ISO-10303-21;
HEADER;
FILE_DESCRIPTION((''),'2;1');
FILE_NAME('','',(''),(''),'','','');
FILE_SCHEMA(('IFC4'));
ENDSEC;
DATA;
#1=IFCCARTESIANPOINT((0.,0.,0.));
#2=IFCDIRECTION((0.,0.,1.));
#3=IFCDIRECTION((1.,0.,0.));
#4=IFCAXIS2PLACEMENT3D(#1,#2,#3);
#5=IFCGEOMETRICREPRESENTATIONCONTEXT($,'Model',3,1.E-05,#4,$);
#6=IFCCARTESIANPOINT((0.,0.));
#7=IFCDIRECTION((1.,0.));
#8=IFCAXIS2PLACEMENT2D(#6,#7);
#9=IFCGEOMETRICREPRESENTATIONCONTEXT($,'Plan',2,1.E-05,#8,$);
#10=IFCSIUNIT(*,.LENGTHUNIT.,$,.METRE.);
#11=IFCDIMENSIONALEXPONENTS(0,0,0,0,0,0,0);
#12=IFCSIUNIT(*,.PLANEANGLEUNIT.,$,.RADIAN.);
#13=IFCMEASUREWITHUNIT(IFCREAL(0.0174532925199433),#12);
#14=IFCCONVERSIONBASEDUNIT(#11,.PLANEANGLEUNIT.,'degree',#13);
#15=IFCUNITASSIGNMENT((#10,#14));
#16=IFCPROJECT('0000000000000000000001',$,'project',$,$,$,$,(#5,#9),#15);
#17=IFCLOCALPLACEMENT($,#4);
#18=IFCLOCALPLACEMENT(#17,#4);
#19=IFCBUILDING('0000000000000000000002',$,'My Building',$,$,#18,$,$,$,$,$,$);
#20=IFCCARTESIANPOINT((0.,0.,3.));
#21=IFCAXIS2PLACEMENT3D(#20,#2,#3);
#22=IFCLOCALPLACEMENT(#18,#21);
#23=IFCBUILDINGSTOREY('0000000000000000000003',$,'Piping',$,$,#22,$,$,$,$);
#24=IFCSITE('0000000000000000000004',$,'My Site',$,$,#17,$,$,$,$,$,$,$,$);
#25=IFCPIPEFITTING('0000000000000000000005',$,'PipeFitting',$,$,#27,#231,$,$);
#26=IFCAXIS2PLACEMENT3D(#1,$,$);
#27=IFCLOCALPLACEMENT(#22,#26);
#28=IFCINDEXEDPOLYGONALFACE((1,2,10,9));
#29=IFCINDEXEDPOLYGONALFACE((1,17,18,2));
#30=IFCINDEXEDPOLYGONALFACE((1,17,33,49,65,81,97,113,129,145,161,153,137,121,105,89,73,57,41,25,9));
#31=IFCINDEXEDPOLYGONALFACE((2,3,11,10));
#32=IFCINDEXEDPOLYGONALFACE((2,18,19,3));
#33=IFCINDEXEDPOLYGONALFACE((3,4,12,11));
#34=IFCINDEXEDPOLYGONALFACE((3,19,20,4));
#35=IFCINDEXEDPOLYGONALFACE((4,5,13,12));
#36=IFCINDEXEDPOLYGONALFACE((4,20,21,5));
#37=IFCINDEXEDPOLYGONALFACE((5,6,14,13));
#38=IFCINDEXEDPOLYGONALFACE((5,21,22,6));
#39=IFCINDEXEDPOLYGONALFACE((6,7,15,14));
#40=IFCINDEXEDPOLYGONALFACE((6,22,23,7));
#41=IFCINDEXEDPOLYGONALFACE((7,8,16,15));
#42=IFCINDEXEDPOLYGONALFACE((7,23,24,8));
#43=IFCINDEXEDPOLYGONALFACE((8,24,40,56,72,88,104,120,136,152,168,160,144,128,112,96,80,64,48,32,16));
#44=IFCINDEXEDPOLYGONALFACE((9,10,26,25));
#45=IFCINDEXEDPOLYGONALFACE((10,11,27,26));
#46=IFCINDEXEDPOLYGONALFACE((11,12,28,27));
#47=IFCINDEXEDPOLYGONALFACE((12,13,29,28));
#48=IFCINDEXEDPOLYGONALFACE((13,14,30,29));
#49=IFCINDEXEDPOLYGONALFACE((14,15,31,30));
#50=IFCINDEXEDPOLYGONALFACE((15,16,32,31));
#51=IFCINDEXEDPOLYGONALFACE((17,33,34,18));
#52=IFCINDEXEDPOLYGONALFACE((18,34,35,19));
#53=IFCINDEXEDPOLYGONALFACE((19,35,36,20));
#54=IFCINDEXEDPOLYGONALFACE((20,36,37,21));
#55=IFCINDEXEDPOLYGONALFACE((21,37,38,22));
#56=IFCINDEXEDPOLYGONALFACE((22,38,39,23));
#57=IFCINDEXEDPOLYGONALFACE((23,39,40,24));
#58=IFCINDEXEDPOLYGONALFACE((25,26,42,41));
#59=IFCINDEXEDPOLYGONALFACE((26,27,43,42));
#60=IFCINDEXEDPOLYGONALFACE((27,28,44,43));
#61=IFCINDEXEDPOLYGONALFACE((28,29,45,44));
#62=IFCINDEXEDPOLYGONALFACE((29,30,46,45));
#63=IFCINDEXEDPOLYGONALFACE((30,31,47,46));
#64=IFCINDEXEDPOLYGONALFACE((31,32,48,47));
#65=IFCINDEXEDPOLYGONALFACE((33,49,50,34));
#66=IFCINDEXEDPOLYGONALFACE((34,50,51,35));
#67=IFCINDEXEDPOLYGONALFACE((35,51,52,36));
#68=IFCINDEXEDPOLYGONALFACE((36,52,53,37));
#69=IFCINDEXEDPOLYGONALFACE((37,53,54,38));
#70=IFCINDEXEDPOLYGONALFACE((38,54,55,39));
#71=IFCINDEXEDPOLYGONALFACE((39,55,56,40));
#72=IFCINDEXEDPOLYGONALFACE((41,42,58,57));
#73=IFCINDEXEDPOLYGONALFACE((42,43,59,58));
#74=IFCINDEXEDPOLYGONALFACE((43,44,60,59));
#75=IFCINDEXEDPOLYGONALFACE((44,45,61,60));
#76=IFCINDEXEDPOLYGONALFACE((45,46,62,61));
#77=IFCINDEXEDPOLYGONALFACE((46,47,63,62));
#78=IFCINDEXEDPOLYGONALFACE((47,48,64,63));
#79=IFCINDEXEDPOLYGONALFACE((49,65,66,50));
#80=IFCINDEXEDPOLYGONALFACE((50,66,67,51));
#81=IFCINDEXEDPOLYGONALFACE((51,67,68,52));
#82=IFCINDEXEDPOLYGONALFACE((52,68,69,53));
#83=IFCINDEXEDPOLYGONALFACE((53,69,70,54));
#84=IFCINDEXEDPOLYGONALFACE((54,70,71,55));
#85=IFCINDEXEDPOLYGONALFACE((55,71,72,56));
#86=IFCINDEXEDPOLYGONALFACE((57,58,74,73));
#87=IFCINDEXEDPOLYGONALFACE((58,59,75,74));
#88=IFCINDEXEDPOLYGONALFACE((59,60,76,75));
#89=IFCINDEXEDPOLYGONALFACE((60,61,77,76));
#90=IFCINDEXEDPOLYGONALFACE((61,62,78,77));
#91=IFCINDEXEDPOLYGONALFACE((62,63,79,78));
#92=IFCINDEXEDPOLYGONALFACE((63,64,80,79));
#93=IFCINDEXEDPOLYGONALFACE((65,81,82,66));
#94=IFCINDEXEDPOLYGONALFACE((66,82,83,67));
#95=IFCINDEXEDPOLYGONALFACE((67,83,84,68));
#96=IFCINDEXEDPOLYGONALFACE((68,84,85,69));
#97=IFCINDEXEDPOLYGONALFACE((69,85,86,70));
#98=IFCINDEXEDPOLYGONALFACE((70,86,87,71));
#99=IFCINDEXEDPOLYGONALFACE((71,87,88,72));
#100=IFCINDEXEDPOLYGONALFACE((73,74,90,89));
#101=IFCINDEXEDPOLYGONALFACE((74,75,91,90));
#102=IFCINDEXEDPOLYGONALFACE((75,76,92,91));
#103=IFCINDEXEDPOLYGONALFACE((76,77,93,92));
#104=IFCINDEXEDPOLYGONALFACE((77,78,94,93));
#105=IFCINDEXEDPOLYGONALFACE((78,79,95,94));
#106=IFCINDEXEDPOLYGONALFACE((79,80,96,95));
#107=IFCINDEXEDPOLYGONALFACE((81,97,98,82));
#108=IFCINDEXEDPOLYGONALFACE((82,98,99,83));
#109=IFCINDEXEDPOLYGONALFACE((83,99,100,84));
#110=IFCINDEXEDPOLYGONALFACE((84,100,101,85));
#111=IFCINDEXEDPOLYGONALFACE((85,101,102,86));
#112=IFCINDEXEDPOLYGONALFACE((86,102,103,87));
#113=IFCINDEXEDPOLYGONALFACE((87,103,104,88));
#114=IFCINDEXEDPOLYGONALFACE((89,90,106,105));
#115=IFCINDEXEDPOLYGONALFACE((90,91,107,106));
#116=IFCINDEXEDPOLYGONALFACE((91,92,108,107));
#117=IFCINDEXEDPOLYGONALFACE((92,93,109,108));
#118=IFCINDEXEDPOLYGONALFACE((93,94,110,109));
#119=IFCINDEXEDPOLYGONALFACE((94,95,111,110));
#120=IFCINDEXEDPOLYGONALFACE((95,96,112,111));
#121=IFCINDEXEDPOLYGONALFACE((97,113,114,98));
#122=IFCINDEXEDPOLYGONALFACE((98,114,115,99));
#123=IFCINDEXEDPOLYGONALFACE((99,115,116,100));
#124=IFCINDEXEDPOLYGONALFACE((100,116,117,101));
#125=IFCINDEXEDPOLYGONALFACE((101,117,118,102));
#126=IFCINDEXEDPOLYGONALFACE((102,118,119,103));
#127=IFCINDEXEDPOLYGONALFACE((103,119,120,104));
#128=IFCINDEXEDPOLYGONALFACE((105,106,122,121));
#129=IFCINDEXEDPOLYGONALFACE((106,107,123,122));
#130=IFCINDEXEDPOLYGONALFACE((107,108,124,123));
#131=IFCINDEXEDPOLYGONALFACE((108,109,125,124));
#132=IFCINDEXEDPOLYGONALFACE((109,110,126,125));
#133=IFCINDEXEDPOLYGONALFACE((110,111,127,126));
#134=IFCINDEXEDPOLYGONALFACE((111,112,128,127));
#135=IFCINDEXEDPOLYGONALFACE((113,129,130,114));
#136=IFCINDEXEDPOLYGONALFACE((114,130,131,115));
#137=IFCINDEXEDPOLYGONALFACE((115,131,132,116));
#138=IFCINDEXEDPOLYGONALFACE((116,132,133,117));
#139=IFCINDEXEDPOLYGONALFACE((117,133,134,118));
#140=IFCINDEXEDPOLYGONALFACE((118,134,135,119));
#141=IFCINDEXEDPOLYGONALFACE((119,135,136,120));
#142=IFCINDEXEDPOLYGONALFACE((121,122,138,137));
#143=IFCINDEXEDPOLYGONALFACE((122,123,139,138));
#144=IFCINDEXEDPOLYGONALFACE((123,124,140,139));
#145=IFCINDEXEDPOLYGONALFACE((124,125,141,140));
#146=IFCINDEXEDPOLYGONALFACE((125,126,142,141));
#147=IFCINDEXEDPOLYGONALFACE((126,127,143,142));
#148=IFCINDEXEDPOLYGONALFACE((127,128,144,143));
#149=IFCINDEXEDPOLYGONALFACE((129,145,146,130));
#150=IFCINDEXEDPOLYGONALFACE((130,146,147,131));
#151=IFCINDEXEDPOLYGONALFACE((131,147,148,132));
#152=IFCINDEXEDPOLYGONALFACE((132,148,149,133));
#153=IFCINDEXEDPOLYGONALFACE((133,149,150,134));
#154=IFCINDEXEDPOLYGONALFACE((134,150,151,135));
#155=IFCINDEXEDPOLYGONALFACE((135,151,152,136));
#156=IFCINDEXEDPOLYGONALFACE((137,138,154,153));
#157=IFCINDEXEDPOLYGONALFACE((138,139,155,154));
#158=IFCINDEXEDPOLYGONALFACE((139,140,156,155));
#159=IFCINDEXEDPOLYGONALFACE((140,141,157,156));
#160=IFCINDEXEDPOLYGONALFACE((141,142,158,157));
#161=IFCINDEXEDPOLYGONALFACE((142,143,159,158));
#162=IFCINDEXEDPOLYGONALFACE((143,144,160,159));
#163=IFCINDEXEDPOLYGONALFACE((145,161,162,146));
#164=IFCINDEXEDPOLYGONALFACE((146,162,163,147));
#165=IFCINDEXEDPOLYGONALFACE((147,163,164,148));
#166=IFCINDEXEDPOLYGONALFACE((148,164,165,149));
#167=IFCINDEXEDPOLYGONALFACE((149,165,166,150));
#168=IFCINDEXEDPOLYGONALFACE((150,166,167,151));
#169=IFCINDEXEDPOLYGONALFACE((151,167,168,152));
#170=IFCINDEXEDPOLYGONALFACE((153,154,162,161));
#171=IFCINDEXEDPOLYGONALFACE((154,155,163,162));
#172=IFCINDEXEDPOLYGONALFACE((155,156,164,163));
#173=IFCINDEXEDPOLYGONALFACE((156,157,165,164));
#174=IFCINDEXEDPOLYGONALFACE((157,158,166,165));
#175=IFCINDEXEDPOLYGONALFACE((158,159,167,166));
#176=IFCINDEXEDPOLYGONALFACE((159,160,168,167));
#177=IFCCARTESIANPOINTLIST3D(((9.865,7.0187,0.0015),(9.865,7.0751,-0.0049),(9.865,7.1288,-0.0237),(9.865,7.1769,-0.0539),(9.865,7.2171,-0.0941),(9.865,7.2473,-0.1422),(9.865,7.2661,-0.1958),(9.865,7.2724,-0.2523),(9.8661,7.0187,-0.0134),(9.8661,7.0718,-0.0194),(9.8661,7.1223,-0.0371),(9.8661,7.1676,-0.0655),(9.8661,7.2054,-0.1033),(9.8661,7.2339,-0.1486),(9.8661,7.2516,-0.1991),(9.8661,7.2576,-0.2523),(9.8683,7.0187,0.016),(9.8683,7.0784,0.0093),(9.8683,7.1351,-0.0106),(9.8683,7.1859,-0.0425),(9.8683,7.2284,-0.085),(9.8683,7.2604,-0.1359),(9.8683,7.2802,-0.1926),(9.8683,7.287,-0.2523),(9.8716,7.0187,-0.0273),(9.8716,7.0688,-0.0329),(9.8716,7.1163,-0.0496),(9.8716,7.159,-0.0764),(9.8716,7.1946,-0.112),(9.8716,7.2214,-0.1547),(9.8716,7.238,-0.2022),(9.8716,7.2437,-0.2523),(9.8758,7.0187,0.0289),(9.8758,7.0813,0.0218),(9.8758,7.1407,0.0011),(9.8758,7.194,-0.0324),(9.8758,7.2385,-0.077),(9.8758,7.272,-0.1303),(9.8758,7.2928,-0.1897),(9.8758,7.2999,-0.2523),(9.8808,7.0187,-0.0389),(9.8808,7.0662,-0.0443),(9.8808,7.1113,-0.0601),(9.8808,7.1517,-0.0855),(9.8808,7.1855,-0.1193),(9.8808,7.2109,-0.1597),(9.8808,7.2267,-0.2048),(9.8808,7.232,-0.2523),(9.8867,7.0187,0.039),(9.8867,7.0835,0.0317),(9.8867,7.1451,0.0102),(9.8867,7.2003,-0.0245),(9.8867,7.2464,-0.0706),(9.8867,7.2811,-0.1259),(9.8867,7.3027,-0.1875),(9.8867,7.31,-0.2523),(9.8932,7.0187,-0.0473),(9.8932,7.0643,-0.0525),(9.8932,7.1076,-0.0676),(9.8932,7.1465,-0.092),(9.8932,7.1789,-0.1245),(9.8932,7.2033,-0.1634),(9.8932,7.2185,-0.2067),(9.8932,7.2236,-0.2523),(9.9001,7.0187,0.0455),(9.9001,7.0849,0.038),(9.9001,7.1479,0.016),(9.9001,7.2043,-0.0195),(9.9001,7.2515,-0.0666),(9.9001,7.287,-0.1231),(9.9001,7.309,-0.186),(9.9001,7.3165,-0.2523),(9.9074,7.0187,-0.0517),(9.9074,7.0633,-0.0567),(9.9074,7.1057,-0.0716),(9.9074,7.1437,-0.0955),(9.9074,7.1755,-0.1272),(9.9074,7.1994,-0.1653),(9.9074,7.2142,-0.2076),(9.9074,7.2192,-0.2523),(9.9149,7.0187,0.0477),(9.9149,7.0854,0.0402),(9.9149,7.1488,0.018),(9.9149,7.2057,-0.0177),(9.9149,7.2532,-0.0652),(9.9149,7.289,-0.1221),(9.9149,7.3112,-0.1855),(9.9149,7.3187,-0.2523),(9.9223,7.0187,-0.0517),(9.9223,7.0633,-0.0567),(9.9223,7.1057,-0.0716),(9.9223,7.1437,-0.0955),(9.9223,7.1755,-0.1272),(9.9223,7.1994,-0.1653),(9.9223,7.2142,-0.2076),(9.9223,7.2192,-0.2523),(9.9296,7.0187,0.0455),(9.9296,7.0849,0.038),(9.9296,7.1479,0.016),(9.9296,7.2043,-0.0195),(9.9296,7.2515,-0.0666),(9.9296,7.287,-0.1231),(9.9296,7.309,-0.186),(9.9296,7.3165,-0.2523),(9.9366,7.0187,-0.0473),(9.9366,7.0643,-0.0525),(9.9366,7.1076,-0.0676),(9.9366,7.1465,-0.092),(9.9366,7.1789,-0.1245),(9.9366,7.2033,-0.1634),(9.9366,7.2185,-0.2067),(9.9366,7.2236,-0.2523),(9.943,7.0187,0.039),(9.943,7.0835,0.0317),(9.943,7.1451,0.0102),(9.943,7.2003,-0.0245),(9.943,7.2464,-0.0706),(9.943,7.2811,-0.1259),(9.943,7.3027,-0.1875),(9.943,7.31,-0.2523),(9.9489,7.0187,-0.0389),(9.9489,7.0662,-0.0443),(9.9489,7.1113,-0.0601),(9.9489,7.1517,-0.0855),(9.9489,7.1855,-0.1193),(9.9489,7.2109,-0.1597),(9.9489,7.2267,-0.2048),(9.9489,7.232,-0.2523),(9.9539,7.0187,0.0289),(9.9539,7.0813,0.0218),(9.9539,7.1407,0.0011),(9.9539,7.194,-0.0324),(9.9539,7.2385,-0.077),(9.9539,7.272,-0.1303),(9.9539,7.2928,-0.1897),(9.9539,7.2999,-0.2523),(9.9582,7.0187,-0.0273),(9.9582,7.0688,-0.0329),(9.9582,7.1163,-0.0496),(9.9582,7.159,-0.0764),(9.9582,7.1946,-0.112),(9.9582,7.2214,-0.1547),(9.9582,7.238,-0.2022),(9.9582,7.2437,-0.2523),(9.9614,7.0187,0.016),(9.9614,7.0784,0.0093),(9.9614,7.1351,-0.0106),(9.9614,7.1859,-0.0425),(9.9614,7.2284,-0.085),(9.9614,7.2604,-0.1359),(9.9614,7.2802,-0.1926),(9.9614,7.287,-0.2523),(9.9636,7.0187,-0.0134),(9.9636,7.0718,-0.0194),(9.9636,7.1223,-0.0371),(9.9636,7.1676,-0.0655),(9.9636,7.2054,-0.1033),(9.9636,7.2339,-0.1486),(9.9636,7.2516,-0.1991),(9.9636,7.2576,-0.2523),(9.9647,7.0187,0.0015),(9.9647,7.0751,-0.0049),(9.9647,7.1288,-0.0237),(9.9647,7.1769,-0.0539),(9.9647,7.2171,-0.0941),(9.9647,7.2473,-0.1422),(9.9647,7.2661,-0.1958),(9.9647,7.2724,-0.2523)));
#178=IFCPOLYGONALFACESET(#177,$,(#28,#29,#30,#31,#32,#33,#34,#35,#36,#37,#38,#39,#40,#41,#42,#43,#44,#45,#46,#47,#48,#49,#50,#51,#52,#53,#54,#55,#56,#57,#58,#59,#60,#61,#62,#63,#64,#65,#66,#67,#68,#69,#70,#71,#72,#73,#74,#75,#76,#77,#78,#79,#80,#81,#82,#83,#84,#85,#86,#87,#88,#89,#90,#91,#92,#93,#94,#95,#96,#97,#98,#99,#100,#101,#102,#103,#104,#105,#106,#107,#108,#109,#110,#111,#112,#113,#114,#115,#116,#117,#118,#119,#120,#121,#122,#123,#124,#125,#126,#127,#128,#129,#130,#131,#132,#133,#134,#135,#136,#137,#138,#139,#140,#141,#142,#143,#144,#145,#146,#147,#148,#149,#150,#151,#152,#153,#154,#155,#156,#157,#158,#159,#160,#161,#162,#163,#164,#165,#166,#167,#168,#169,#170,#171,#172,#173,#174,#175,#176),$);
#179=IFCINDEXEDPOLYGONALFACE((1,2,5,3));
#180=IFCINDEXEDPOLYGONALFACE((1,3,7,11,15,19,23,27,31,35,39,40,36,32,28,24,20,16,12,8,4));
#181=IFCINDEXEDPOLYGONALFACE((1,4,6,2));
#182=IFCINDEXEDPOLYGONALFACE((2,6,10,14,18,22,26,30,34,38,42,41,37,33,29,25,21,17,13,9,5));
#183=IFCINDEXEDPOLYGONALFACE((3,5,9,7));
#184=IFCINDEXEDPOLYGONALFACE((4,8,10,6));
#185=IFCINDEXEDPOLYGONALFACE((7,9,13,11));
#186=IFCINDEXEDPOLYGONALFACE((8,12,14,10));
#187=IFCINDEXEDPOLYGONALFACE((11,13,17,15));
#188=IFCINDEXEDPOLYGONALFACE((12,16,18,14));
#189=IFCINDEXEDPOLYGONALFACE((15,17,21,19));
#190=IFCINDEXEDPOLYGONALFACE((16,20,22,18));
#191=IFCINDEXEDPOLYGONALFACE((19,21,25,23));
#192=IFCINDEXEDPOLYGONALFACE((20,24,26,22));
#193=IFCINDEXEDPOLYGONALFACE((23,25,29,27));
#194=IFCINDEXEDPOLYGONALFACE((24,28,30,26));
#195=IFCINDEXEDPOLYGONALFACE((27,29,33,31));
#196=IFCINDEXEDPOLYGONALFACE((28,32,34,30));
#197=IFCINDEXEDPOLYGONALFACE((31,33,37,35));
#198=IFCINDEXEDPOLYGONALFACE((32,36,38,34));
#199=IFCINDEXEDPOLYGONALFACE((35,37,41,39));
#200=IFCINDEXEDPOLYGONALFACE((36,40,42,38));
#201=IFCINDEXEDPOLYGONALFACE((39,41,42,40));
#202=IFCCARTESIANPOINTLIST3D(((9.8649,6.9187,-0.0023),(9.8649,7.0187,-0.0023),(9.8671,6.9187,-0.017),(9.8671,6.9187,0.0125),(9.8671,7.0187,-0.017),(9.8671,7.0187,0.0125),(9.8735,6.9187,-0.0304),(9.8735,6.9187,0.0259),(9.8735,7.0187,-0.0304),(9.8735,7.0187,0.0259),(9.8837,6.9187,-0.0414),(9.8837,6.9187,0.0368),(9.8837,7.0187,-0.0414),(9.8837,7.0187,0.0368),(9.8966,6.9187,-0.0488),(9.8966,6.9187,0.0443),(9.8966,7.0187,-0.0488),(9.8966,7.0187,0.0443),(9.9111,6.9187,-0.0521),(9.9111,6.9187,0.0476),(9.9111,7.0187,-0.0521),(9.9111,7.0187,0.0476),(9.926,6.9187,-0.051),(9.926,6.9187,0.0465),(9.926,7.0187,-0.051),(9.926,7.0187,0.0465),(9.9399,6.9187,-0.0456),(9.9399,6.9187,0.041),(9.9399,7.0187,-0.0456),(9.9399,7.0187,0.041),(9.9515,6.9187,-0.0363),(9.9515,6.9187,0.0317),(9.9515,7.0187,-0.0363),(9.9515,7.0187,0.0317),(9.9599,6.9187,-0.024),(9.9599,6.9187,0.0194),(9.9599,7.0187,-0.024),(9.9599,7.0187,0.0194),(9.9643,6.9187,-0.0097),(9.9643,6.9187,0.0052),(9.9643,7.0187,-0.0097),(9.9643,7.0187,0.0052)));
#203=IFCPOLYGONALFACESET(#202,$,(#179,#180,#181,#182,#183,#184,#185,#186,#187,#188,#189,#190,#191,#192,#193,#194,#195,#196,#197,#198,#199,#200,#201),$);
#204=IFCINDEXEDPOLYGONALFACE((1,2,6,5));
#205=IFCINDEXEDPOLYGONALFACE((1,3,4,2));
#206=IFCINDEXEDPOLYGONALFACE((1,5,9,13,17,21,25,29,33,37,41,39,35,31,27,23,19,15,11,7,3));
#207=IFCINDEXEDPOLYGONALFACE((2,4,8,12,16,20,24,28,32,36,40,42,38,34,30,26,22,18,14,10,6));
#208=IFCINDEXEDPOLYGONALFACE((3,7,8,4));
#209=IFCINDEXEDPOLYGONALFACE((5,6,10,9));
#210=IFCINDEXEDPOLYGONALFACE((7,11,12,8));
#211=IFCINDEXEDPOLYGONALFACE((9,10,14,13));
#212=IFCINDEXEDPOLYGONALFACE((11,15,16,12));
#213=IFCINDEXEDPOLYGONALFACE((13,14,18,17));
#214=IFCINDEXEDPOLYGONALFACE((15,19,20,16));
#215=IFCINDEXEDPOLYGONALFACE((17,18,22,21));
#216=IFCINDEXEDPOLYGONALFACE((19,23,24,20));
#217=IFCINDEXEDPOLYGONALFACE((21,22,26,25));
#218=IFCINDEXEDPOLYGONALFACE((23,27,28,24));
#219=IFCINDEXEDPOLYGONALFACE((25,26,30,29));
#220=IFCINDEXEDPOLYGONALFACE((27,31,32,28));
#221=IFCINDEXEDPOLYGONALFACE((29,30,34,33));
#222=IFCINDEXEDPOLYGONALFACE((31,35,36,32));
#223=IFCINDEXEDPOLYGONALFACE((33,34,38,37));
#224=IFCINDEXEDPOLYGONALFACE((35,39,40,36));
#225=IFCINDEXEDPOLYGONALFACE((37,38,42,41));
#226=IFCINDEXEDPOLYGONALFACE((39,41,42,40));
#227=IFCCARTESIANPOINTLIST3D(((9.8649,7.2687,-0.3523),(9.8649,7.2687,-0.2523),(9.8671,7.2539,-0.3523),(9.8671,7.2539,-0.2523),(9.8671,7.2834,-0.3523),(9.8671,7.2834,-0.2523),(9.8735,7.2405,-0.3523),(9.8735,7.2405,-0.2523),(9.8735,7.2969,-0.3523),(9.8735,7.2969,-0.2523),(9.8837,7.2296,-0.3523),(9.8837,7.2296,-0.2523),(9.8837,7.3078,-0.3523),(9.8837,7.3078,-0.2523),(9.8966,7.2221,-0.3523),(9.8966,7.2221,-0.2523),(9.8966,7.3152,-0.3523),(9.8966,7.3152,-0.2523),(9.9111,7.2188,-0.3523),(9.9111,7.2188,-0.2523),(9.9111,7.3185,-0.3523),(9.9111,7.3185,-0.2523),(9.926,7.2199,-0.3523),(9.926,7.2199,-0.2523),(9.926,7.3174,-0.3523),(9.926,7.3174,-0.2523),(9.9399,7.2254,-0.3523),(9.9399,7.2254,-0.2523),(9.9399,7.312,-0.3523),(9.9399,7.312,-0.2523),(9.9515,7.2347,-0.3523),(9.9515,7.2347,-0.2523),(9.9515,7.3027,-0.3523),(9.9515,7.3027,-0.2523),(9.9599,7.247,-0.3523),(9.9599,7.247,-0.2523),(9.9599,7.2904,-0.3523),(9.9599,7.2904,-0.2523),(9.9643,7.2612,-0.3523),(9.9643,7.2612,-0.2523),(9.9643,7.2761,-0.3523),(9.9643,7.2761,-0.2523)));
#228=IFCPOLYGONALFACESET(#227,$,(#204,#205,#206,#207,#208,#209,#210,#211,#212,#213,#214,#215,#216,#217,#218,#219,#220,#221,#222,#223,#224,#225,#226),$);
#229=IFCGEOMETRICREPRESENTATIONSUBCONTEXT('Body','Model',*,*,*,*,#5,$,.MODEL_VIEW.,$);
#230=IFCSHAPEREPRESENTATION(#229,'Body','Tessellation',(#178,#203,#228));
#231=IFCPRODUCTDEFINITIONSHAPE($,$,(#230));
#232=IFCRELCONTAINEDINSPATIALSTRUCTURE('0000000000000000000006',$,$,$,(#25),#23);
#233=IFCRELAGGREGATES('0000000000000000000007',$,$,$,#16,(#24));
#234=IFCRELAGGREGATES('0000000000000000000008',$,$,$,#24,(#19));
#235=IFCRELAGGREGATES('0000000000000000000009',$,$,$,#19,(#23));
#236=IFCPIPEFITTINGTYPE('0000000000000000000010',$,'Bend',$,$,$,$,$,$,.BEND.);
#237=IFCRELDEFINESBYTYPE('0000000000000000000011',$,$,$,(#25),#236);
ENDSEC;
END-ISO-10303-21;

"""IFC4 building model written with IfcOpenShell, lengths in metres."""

from ifc_helpers import new_model, entity, si_unit, converted_unit, frame, origin_with_axes, origin_2d_with_axis, place, context, subcontext, project, spatial, circle, extrude, source, transform, mapped, type_object, type_shapes, element, save


model = new_model("IFC4")

# Units and contexts
model_context = context("Model", 3, precision=1e-05, world=origin_with_axes())
plan_context = context("Plan", 2, precision=1e-05, world=origin_2d_with_axis())
body_context = subcontext(model_context, "Body", "Model", "MODEL_VIEW")
ifc_project = project(units=[si_unit("LENGTHUNIT", "METRE"), converted_unit("PLANEANGLEUNIT", "degree", entity("IfcReal", 0.0174532925199433), si_unit("PLANEANGLEUNIT", "RADIAN"), dimensions=[0, 0, 0, 0, 0, 0, 0])], contexts=[model_context, plan_context])

# Site, building, storey
site_placement = place(None, origin_with_axes())
site = spatial("IfcSite", under=ifc_project, at=site_placement, Name="My Site")
building_placement = place(site_placement, origin_with_axes())
building = spatial("IfcBuilding", under=site, at=building_placement, Name="My Building")
storey_placement = place(building_placement, frame((0.0, 0.0, 3.0), z_axis=(0.0, 0.0, 1.0), x_axis=(1.0, 0.0, 0.0)))
storey = spatial("IfcBuildingStorey", under=building, at=storey_placement, Name="Piping")

# Pipe fitting
pipe_fitting_type_1 = type_object("IfcPipeFittingType", Name="Bend", PredefinedType="BEND")
shared_shape = source(origin_with_axes(), body_context, "Body", "SolidModel", [
    entity("IfcSweptDiskSolid", entity("IfcIndexedPolyCurve", entity("IfcCartesianPointList3D", [[0.0, 0.0, -0.1], [0.0, 0.0732, -0.2768], [0.0, 0.25, -0.35]]), [entity("IfcArcIndex", [1, 2, 3])]), 0.05),
    extrude(circle(Radius=0.05), origin_with_axes(), (0.0, 0.0, -1.0), 0.1),
    extrude(circle(Radius=0.05), frame((0.0, 0.25, -0.35), z_axis=(0.0, 1.0, 0.0), x_axis=(1.0, 0.0, 0.0)), (0.0, 0.0, 1.0), 0.1),
])
type_shapes(pipe_fitting_type_1, [shared_shape])
for number, where, z_axis, x_axis, name in (
    (1, (9.9149, 6.9187, -0.0023), (0.0, -1.0, 0.0), (-1.0, 0.0, 0.0), "PipeFitting"),
):
    element("IfcPipeFitting", number, at=place(storey_placement, frame(where, z_axis=z_axis, x_axis=x_axis)), inside=storey, type_object=pipe_fitting_type_1, Name=name, context=body_context, shape_type="MappedRepresentation", body=[
        mapped(shared_shape, transform((0.0, 0.0, 0.0), x_axis=(1.0, 0.0, 0.0), y_axis=(0.0, 1.0, 0.0), z_axis=(0.0, 0.0, 1.0), scale=1.0)),
    ])

save(model, "model.ifc")
